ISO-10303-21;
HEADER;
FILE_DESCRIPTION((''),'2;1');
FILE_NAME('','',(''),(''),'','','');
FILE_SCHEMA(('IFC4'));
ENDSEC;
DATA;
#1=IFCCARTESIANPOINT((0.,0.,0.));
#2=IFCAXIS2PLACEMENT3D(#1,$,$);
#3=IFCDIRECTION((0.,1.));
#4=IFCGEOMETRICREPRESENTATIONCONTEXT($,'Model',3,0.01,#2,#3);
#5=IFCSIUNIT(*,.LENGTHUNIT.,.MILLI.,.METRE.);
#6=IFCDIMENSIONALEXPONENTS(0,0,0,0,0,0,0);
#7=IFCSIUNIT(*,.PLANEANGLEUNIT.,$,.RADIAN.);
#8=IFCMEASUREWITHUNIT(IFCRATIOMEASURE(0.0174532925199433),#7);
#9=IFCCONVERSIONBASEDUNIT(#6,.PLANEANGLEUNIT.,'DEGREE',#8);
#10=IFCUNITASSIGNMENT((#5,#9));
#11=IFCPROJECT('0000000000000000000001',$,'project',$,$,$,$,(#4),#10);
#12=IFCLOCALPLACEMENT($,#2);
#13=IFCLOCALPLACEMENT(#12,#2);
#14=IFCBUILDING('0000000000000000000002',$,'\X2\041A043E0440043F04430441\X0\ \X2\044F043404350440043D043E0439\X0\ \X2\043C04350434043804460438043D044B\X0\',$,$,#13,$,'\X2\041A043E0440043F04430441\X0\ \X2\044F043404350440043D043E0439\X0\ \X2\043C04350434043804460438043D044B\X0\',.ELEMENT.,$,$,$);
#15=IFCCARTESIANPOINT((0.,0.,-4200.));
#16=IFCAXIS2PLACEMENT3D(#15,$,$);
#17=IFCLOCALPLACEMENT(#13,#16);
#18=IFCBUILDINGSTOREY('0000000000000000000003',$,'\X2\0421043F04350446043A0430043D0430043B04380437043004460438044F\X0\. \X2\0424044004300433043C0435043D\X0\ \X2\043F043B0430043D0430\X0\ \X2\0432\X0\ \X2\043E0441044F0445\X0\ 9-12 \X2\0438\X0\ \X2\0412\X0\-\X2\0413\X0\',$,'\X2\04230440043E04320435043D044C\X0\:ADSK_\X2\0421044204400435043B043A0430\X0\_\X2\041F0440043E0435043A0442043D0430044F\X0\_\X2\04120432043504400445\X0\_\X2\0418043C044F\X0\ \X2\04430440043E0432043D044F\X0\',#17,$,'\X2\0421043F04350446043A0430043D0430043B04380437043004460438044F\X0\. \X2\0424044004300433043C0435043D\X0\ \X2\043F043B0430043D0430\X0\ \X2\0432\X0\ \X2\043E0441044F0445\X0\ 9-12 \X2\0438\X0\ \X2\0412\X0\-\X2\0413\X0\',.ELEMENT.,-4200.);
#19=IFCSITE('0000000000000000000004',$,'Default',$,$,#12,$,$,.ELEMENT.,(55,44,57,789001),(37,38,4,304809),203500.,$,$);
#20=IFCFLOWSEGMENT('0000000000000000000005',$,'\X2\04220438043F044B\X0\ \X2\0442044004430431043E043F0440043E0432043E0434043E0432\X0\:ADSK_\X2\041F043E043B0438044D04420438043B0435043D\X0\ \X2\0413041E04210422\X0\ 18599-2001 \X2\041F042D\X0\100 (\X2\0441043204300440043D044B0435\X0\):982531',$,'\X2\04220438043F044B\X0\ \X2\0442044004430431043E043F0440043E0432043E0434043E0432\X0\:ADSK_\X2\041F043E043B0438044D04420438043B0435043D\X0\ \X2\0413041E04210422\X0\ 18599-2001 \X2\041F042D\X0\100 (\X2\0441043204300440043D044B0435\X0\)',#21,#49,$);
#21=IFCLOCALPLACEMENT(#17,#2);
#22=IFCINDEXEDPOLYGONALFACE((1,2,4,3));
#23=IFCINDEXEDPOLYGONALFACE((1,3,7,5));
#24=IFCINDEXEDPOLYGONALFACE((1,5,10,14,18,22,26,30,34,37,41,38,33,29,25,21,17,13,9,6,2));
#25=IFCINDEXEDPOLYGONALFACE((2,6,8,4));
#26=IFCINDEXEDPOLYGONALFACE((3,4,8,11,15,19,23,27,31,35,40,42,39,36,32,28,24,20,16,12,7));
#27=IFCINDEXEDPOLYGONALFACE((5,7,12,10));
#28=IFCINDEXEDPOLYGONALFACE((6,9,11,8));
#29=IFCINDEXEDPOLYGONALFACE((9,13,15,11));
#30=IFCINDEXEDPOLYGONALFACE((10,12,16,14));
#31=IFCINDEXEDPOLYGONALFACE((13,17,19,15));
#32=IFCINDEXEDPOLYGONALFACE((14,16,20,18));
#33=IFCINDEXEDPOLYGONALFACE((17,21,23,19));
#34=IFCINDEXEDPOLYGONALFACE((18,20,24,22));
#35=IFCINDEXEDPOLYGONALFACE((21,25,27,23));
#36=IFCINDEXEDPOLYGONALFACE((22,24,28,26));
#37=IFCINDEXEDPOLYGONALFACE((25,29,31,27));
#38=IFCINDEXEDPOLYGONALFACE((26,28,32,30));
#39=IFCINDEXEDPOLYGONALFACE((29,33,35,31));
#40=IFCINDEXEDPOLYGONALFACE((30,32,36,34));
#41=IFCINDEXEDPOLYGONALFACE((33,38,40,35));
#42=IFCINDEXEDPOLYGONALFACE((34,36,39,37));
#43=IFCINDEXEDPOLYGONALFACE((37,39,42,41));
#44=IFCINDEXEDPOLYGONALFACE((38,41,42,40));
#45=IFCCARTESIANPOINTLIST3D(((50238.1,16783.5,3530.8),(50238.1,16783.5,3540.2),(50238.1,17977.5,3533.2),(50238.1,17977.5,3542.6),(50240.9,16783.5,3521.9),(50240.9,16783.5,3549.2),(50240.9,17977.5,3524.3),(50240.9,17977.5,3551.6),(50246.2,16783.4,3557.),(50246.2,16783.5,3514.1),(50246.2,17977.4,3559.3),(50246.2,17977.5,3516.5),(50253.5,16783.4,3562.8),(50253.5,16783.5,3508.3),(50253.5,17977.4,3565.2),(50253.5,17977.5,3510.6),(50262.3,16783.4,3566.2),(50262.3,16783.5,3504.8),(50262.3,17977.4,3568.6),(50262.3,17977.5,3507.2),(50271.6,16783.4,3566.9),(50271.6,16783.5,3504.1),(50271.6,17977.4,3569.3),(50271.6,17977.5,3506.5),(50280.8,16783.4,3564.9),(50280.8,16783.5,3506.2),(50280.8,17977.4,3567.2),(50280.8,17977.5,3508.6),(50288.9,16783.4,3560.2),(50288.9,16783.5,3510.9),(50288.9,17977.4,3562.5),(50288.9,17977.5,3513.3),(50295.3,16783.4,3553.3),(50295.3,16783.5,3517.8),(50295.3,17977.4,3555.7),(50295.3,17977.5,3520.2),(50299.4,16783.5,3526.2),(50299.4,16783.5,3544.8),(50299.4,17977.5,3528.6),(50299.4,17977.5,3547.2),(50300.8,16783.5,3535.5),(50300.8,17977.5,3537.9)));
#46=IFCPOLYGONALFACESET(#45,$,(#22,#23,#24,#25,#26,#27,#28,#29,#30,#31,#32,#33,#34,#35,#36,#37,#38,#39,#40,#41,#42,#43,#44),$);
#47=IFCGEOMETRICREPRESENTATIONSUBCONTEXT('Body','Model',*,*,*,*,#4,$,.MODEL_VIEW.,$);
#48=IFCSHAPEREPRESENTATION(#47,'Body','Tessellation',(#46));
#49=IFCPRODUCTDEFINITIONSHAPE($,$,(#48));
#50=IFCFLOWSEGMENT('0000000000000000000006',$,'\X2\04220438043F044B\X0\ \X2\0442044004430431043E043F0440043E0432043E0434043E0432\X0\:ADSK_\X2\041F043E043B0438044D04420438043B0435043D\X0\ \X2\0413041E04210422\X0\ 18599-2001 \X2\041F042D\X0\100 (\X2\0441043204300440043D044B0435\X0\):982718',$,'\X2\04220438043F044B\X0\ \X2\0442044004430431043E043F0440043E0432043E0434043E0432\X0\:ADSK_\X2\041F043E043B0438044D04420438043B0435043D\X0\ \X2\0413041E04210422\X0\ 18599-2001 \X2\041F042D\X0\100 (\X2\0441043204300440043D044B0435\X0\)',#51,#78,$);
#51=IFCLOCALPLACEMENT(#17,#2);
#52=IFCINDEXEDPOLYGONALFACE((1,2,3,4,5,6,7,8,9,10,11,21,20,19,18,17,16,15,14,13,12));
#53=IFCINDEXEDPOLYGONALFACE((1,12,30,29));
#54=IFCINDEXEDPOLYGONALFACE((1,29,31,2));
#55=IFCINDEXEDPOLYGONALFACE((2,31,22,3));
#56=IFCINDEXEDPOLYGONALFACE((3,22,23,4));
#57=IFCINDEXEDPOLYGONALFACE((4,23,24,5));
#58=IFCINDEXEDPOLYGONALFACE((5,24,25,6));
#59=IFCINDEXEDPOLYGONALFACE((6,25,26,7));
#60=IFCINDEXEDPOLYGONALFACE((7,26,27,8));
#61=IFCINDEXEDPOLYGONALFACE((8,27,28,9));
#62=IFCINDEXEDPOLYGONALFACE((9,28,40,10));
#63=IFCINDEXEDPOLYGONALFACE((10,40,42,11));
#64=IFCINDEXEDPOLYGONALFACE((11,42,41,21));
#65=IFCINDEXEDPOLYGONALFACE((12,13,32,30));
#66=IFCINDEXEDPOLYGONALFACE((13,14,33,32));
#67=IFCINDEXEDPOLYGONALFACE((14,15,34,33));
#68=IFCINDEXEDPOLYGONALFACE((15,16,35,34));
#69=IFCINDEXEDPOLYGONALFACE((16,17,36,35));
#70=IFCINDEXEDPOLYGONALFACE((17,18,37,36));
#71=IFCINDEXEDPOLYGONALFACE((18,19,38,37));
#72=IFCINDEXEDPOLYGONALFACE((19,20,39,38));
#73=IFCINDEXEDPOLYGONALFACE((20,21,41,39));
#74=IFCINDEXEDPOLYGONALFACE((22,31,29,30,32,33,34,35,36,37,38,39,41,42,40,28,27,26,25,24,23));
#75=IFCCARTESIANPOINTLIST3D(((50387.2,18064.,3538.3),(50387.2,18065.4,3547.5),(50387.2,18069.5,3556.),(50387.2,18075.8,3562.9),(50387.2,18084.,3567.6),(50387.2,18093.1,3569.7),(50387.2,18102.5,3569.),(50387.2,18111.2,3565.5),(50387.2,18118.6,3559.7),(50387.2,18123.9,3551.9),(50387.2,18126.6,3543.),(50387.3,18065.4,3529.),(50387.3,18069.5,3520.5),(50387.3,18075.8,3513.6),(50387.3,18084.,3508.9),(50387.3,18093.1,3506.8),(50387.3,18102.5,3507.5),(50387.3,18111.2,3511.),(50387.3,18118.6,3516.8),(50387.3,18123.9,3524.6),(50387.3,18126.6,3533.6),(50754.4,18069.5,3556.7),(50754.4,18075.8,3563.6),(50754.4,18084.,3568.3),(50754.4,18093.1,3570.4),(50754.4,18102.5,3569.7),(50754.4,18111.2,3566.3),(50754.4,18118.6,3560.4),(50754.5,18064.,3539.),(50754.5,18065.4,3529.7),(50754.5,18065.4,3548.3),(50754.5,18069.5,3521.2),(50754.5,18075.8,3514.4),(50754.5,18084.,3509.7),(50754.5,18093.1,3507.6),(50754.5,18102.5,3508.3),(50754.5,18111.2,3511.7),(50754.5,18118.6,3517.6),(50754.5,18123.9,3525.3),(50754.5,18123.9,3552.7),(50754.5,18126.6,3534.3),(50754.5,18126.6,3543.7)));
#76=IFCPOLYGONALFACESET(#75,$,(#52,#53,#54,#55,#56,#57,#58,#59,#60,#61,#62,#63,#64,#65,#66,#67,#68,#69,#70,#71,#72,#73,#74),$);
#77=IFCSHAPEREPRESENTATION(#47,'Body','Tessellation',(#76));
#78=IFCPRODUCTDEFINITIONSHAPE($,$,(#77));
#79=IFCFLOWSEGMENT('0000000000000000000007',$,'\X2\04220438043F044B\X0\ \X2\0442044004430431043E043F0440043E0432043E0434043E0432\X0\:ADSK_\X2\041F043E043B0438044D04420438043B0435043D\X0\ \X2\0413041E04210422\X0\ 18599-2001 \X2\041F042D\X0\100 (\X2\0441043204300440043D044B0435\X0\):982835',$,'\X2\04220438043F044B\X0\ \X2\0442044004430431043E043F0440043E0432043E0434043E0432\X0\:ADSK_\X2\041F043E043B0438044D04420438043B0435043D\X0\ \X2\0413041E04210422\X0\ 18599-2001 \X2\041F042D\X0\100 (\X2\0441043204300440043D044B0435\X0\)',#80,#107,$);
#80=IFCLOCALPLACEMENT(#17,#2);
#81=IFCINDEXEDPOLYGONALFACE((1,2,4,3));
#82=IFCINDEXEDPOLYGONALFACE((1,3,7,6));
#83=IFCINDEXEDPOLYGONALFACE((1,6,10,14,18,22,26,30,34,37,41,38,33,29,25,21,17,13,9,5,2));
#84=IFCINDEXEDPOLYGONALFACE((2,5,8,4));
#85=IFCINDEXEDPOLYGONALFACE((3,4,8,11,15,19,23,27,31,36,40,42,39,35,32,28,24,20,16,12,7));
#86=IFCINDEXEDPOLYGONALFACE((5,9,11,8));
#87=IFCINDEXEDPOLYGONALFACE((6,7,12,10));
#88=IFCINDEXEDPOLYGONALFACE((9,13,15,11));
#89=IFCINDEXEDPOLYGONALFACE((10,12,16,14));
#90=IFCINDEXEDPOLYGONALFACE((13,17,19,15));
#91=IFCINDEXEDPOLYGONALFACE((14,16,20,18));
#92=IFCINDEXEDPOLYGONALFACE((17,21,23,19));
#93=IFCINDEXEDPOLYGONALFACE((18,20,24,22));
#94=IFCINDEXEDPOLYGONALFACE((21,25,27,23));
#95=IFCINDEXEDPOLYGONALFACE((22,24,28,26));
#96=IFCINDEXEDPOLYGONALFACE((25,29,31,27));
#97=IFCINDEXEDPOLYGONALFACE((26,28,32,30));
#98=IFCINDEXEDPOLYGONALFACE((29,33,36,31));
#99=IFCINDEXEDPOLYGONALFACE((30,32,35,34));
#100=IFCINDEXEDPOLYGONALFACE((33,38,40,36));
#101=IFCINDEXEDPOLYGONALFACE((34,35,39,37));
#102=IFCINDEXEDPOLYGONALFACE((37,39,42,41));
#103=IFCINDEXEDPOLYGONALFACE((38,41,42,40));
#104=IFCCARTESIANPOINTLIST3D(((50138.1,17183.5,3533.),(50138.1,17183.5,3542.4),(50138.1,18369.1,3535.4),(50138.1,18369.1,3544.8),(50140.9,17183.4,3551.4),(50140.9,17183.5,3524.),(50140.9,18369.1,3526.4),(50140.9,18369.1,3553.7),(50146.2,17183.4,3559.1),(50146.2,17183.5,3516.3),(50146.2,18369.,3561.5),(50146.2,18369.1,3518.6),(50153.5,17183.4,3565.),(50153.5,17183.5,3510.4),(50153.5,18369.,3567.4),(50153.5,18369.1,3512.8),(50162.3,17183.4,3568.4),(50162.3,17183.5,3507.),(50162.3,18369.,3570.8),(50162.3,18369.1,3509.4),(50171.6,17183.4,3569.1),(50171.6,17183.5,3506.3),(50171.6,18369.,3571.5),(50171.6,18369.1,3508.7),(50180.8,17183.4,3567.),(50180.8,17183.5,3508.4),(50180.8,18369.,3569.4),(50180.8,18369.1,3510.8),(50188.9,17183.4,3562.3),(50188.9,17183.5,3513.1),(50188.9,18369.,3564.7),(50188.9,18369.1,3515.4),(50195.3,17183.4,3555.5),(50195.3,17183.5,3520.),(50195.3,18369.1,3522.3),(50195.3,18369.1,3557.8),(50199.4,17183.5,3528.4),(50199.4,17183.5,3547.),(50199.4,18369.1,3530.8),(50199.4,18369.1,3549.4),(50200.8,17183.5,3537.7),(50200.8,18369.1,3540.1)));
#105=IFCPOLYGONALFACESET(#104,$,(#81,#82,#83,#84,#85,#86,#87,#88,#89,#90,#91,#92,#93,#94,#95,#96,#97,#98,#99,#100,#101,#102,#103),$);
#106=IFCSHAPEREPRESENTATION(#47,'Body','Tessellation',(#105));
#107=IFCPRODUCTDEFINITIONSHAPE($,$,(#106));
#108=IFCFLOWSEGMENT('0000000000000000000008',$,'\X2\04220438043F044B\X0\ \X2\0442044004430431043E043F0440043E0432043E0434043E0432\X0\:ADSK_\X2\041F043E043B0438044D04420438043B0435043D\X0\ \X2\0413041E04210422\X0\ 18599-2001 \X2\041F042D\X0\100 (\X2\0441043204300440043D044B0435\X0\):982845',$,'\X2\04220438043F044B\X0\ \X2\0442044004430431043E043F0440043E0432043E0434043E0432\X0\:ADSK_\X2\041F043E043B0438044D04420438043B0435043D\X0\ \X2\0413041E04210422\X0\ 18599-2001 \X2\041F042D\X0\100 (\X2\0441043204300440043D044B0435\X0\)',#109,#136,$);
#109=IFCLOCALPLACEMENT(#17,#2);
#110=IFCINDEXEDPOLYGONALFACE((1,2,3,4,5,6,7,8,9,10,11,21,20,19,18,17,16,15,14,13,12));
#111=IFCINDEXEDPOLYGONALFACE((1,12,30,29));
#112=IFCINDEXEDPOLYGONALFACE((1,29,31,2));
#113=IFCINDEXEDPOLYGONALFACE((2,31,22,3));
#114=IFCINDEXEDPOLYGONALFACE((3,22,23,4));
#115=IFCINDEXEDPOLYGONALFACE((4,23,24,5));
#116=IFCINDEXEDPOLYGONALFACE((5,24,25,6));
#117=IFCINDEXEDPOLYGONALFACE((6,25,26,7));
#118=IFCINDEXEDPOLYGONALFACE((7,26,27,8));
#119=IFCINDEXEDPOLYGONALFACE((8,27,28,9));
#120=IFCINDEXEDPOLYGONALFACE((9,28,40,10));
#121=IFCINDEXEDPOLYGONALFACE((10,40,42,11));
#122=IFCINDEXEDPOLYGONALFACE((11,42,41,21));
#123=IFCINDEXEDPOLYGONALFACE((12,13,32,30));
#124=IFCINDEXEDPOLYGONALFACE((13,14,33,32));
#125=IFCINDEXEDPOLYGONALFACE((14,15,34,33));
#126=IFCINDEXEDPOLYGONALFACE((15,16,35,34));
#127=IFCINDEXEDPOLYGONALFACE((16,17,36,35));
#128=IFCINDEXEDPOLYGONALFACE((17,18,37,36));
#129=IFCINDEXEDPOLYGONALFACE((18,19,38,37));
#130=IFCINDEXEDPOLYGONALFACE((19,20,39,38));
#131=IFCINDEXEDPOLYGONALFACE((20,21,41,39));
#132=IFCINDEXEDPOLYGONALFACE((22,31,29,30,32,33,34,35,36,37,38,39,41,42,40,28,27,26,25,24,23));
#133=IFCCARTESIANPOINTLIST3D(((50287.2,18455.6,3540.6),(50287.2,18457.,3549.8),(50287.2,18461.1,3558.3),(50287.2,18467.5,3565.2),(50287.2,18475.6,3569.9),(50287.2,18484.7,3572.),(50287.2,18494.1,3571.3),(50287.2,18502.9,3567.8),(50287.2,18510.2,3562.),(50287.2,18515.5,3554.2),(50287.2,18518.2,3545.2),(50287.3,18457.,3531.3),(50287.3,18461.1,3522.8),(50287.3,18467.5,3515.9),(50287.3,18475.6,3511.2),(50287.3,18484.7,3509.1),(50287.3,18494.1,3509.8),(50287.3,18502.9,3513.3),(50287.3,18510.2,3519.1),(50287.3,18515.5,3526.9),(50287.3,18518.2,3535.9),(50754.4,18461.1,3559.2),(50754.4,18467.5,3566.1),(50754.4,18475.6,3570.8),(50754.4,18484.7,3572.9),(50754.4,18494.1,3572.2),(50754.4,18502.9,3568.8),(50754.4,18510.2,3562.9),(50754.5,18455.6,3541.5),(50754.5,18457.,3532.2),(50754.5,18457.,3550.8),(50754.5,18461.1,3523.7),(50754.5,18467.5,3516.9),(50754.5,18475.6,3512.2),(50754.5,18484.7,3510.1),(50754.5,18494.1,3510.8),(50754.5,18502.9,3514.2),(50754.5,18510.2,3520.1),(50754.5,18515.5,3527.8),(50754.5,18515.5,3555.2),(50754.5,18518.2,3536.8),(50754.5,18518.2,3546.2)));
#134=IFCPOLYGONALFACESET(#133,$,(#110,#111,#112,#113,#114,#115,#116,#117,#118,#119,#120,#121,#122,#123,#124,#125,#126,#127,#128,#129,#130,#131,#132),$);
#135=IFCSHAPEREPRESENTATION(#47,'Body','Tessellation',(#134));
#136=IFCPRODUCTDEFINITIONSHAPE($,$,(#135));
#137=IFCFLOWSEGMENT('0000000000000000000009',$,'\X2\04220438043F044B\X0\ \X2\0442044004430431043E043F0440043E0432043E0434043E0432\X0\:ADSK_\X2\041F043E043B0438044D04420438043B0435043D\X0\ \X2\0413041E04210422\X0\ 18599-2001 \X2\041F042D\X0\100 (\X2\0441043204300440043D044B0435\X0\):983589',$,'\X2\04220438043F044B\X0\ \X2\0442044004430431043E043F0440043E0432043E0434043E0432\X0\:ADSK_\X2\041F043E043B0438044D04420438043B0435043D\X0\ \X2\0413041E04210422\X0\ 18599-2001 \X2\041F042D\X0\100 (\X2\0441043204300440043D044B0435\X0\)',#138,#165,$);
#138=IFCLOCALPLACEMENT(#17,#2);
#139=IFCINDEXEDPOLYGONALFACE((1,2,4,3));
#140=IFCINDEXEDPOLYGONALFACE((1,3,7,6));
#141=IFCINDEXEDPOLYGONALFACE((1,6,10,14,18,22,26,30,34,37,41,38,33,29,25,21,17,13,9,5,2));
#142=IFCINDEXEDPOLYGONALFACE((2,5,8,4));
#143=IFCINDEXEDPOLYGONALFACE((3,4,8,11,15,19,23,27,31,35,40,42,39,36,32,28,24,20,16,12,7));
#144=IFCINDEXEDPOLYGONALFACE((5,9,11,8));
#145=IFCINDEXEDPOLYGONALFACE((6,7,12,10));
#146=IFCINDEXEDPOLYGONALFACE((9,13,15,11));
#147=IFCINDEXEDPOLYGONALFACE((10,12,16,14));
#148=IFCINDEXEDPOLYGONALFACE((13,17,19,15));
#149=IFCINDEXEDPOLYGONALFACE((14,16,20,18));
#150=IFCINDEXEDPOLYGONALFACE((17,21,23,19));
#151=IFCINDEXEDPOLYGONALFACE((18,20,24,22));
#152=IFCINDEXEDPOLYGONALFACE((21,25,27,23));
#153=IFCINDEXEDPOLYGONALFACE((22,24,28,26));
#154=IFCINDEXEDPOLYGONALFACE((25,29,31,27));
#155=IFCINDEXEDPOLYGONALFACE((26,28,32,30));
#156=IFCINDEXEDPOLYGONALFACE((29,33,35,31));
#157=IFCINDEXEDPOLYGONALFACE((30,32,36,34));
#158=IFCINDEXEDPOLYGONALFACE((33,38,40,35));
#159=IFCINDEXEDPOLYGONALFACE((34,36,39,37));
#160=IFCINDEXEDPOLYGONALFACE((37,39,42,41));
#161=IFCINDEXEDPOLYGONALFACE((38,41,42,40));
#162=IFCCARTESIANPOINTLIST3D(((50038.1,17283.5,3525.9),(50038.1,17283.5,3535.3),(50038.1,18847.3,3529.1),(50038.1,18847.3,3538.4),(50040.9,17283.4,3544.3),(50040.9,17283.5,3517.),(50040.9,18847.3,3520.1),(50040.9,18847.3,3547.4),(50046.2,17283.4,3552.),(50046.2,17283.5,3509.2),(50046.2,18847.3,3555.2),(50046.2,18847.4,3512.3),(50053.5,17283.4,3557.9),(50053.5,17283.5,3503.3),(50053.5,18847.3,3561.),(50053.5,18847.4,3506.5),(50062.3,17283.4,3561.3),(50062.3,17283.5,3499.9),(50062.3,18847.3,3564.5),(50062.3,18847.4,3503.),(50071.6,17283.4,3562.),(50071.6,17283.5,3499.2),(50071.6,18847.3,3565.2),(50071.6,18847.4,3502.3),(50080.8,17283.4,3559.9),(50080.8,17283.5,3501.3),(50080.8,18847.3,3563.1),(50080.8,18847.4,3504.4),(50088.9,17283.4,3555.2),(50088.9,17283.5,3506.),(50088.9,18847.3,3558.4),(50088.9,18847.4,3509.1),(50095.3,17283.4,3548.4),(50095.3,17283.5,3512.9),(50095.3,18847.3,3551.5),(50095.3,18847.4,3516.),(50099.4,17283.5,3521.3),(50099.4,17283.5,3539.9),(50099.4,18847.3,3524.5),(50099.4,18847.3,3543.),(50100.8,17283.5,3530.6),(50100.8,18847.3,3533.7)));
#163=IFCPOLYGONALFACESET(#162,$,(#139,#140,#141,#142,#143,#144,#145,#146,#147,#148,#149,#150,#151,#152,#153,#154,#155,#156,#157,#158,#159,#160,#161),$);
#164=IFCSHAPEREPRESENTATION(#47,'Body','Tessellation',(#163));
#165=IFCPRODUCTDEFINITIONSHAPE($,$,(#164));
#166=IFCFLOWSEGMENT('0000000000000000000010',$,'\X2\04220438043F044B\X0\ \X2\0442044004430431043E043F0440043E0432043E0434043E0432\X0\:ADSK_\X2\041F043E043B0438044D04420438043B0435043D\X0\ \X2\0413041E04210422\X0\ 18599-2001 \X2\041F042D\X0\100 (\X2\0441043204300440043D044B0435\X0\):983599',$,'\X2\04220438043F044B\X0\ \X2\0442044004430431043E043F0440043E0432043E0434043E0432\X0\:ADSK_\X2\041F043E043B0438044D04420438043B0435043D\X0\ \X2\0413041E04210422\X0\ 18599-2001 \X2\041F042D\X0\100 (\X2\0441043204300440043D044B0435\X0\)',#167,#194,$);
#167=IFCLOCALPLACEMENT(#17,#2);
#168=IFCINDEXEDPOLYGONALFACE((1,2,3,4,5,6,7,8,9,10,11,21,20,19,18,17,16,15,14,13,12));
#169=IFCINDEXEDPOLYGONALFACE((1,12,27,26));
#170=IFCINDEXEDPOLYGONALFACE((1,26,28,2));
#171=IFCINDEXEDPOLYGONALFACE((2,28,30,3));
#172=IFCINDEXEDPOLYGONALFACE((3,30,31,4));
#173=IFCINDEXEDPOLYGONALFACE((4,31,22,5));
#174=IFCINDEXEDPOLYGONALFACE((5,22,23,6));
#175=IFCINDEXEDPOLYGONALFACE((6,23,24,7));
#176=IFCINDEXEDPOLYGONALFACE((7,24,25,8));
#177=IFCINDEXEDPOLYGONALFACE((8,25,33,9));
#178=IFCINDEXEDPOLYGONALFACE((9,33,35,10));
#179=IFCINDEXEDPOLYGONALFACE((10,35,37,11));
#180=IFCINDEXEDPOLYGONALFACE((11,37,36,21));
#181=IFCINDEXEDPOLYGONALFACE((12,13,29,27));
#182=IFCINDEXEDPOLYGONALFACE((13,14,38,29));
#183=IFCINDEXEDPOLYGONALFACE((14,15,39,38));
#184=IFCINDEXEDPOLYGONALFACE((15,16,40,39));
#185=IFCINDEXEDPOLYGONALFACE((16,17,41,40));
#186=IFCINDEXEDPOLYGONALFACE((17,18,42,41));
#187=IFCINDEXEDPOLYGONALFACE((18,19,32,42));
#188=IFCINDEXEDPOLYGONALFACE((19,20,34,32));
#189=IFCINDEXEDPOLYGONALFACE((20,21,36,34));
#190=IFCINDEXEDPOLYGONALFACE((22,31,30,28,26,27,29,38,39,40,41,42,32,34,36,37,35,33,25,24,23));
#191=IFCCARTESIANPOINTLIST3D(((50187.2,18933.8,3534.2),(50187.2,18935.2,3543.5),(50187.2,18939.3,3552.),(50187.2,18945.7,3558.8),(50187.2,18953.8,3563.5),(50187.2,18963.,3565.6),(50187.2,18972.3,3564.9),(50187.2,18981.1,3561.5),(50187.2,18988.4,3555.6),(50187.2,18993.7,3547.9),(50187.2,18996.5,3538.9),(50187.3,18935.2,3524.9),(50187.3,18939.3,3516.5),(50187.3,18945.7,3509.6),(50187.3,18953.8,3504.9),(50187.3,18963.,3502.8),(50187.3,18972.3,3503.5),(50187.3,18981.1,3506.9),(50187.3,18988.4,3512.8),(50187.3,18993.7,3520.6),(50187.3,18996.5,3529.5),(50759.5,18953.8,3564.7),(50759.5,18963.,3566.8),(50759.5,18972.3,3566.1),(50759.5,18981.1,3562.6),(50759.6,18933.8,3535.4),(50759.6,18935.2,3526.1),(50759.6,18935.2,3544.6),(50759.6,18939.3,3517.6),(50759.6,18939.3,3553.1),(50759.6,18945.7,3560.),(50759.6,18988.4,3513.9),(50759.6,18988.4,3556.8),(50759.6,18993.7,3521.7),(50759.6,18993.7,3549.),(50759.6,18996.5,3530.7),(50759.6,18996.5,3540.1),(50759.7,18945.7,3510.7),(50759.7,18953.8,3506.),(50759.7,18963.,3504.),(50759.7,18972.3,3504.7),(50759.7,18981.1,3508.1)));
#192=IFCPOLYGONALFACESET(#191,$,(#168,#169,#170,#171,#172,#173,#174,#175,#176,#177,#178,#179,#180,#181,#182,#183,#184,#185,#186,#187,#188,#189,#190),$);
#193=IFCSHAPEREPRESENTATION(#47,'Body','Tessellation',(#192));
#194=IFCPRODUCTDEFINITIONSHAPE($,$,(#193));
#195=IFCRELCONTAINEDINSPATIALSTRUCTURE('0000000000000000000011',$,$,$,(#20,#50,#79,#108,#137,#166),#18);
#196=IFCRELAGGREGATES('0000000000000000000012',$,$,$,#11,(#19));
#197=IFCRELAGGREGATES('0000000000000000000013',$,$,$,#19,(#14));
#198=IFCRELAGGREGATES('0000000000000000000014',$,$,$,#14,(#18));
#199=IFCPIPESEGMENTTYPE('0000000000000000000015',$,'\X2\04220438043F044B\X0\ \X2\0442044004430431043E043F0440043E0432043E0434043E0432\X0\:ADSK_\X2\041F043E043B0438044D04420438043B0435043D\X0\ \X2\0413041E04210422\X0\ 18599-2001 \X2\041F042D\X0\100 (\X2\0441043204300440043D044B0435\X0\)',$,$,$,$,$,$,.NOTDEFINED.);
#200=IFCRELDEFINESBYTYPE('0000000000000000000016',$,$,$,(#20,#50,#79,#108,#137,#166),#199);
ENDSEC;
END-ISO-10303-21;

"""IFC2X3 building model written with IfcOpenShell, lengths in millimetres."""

from ifc_helpers import new_model, entity, si_unit, converted_unit, direction, frame, origin, origin_2d_with_axis, place, context, subcontext, project, spatial, circle, extrude, type_object, element, save


model = new_model("IFC2X3")

# Units and contexts
model_context = context("Model", 3, precision=0.01, world=origin(), true_north=direction((0.0, 1.0)))
body_context = subcontext(model_context, "Body", "Model", "MODEL_VIEW")
ifc_project = project(units=[si_unit("LENGTHUNIT", "METRE", prefix="MILLI"), converted_unit("PLANEANGLEUNIT", "DEGREE", entity("IfcRatioMeasure", 0.0174532925199433), si_unit("PLANEANGLEUNIT", "RADIAN"), dimensions=[0, 0, 0, 0, 0, 0, 0])], contexts=[model_context])

# Site, building, storey
site_placement = place(None, origin())
site = spatial("IfcSite", under=ifc_project, at=site_placement, Name="Default", CompositionType="ELEMENT", RefLatitude=(55, 44, 57, 789001), RefLongitude=(37, 38, 4, 304809), RefElevation=203500.0)
building_placement = place(site_placement, origin())
building = spatial("IfcBuilding", under=site, at=building_placement, Name="Корпус ядерной медицины", LongName="Корпус ядерной медицины", CompositionType="ELEMENT")
storey_placement = place(building_placement, frame((0.0, 0.0, -4200.0)))
storey = spatial("IfcBuildingStorey", under=building, at=storey_placement, Name="Спецканализация. Фрагмен плана в осях 9-12 и В-Г", ObjectType="Уровень:ADSK_Стрелка_Проектная_Вверх_Имя уровня", LongName="Спецканализация. Фрагмен плана в осях 9-12 и В-Г", CompositionType="ELEMENT", Elevation=-4200.0)

# Flow segments
pipe_segment_type = type_object("IfcPipeSegmentType", Name="Типы трубопроводов:ADSK_Полиэтилен ГОСТ 18599-2001 ПЭ100 (сварные)", PredefinedType="NOTDEFINED")
flow_segment_1_placement = place(storey_placement, frame((50236.2, 16783.4, 3502.4)))
element("IfcFlowSegment", 1, at=flow_segment_1_placement, inside=storey, type_object=pipe_segment_type, Name="Типы трубопроводов:ADSK_Полиэтилен ГОСТ 18599-2001 ПЭ100 (сварные):982531", ObjectType="Типы трубопроводов:ADSK_Полиэтилен ГОСТ 18599-2001 ПЭ100 (сварные)", context=body_context, shape_type="SweptSolid", body=[
    extrude(circle(Radius=31.5, at=origin_2d_with_axis()), frame((33.1, 0.1, 33.1), z_axis=(0.0, 0.999998, 0.002), x_axis=(1.0, 0.0, 0.0)), (0.0, 0.0, 1.0), 1194.0),
])
flow_segment_2_placement = place(storey_placement, frame((50387.2, 18062.4, 3505.2)))
element("IfcFlowSegment", 2, at=flow_segment_2_placement, inside=storey, type_object=pipe_segment_type, Name="Типы трубопроводов:ADSK_Полиэтилен ГОСТ 18599-2001 ПЭ100 (сварные):982718", ObjectType="Типы трубопроводов:ADSK_Полиэтилен ГОСТ 18599-2001 ПЭ100 (сварные)", context=body_context, shape_type="SweptSolid", body=[
    extrude(circle(Radius=31.5, at=origin_2d_with_axis()), frame((0.1, 33.1, 33.1), z_axis=(0.999998, 0.0, 0.001973), x_axis=(0.0, -1.0, 0.0)), (0.0, 0.0, 1.0), 367.2),
])
flow_segment_3_placement = place(storey_placement, frame((50136.2, 17183.4, 3504.6)))
element("IfcFlowSegment", 3, at=flow_segment_3_placement, inside=storey, type_object=pipe_segment_type, Name="Типы трубопроводов:ADSK_Полиэтилен ГОСТ 18599-2001 ПЭ100 (сварные):982835", ObjectType="Типы трубопроводов:ADSK_Полиэтилен ГОСТ 18599-2001 ПЭ100 (сварные)", context=body_context, shape_type="SweptSolid", body=[
    extrude(circle(Radius=31.5, at=origin_2d_with_axis()), frame((33.1, 0.1, 33.1), z_axis=(0.0, 0.999998, 0.001995), x_axis=(1.0, 0.0, 0.0)), (0.0, 0.0, 1.0), 1185.6),
])
flow_segment_4_placement = place(storey_placement, frame((50287.2, 18454.0, 3507.4)))
element("IfcFlowSegment", 4, at=flow_segment_4_placement, inside=storey, type_object=pipe_segment_type, Name="Типы трубопроводов:ADSK_Полиэтилен ГОСТ 18599-2001 ПЭ100 (сварные):982845", ObjectType="Типы трубопроводов:ADSK_Полиэтилен ГОСТ 18599-2001 ПЭ100 (сварные)", context=body_context, shape_type="SweptSolid", body=[
    extrude(circle(Radius=31.5, at=origin_2d_with_axis()), frame((0.1, 33.1, 33.1), z_axis=(0.999998, 0.0, 0.002004), x_axis=(0.0, -1.0, 0.0)), (0.0, 0.0, 1.0), 467.2),
])
flow_segment_5_placement = place(storey_placement, frame((50036.2, 17283.4, 3497.5)))
element("IfcFlowSegment", 5, at=flow_segment_5_placement, inside=storey, type_object=pipe_segment_type, Name="Типы трубопроводов:ADSK_Полиэтилен ГОСТ 18599-2001 ПЭ100 (сварные):983589", ObjectType="Типы трубопроводов:ADSK_Полиэтилен ГОСТ 18599-2001 ПЭ100 (сварные)", context=body_context, shape_type="SweptSolid", body=[
    extrude(circle(Radius=31.5, at=origin_2d_with_axis()), frame((33.1, 0.1, 33.1), z_axis=(0.0, 0.999998, 0.002), x_axis=(1.0, 0.0, 0.0)), (0.0, 0.0, 1.0), 1563.9),
])
flow_segment_6_placement = place(storey_placement, frame((50187.2, 18932.2, 3501.1)))
element("IfcFlowSegment", 6, at=flow_segment_6_placement, inside=storey, type_object=pipe_segment_type, Name="Типы трубопроводов:ADSK_Полиэтилен ГОСТ 18599-2001 ПЭ100 (сварные):983599", ObjectType="Типы трубопроводов:ADSK_Полиэтилен ГОСТ 18599-2001 ПЭ100 (сварные)", context=body_context, shape_type="SweptSolid", body=[
    extrude(circle(Radius=31.5, at=origin_2d_with_axis()), frame((0.1, 33.1, 33.1), z_axis=(0.999998, 0.0, 0.002), x_axis=(0.0, -1.0, 0.0)), (0.0, 0.0, 1.0), 572.4),
])

save(model, "model.ifc")
